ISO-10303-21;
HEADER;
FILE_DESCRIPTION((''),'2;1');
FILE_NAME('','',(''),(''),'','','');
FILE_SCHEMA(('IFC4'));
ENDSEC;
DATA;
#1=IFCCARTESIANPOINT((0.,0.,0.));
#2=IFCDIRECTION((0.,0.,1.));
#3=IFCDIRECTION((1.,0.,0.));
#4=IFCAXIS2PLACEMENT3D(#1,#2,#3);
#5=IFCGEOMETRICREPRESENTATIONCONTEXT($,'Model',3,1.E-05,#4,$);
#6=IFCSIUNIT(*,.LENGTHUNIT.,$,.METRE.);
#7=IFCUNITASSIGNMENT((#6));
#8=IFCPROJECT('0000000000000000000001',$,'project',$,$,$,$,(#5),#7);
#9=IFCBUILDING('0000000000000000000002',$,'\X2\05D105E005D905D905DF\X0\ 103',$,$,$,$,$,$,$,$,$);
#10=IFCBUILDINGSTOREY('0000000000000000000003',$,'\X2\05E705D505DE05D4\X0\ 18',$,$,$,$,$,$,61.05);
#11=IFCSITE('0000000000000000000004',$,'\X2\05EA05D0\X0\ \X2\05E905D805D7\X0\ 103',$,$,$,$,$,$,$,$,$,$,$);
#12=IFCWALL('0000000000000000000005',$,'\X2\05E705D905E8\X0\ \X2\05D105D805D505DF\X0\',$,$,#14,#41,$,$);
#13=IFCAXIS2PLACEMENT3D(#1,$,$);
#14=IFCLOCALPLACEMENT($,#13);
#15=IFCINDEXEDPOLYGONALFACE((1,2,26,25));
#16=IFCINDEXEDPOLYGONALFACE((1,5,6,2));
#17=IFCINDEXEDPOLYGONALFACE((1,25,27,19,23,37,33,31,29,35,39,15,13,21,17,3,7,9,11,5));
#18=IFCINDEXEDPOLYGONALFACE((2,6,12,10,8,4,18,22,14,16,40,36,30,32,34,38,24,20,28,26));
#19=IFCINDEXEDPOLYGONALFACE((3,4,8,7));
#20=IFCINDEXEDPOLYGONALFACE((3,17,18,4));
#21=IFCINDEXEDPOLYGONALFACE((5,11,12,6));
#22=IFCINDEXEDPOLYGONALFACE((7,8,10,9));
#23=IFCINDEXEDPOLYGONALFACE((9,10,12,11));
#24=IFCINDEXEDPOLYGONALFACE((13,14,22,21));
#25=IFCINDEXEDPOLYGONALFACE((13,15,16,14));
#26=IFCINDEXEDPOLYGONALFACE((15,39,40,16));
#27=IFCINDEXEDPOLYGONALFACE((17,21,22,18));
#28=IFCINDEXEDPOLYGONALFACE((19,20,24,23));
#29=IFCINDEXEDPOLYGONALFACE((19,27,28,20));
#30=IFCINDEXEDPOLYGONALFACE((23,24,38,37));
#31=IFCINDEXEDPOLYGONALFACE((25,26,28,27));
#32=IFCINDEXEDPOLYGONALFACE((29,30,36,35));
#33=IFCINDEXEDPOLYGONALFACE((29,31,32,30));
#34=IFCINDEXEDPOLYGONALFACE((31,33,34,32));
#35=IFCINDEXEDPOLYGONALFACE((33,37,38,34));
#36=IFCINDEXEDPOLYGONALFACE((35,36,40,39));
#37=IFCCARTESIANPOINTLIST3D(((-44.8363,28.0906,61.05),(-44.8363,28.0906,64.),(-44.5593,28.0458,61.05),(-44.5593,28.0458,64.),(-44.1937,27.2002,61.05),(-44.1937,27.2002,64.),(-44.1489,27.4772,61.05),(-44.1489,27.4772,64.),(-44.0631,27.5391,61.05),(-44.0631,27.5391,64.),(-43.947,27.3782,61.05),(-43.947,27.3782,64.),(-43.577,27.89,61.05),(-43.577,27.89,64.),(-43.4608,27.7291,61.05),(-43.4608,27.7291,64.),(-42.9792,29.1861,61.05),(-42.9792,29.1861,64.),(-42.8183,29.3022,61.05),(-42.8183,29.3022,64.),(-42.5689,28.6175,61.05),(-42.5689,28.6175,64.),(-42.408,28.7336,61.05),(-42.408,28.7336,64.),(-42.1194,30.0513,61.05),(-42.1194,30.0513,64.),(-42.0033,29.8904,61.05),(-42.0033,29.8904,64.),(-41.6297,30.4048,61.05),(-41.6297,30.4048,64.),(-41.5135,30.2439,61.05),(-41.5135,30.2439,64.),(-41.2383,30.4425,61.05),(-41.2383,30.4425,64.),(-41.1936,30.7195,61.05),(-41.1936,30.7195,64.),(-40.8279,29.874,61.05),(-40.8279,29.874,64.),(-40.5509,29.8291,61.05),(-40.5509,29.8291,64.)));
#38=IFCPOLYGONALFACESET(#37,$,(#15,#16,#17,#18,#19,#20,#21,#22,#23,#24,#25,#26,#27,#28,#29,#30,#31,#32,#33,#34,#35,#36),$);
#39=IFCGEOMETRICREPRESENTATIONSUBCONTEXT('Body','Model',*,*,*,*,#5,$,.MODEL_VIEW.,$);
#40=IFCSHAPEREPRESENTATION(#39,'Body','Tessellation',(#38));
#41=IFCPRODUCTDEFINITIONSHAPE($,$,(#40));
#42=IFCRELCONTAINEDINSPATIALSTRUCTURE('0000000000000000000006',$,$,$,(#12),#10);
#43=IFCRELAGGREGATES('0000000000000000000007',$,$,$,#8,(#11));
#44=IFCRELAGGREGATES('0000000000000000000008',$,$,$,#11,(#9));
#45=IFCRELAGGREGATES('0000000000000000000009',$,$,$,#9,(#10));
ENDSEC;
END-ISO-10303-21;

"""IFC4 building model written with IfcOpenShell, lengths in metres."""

from ifc_helpers import new_model, si_unit, frame, origin_with_axes, context, subcontext, project, spatial, polyline, outline, extrude, element, save


model = new_model("IFC4")

# Units and contexts
model_context = context("Model", 3, precision=1e-05, world=origin_with_axes())
body_context = subcontext(model_context, "Body", "Model", "MODEL_VIEW")
ifc_project = project(units=[si_unit("LENGTHUNIT", "METRE")], contexts=[model_context])

# Site, building, storey
site = spatial("IfcSite", under=ifc_project, Name="תא שטח 103")
building = spatial("IfcBuilding", under=site, Name="בניין 103")
storey = spatial("IfcBuildingStorey", under=building, Name="קומה 18", Elevation=61.05)

# Wall
element("IfcWall", 1, inside=storey, Name="קיר בטון", context=body_context, shape_type="SweptSolid", body=[
    extrude(outline(polyline([(-43.947, 27.3782), (-44.1937, 27.2002), (-44.8363, 28.0906), (-42.1194, 30.0513), (-42.0033, 29.8904), (-42.8183, 29.3022), (-42.408, 28.7336), (-40.8279, 29.874), (-41.2383, 30.4425), (-41.5135, 30.2439), (-41.6297, 30.4048), (-41.1936, 30.7195), (-40.5509, 29.8291), (-43.4608, 27.7291), (-43.577, 27.89), (-42.5689, 28.6175), (-42.9792, 29.1861), (-44.5593, 28.0458), (-44.1489, 27.4772), (-44.0631, 27.5391), (-43.947, 27.3782)])), frame((0.0, 0.0, 61.05)), (0.0, 0.0, 1.0), 2.95),
])

save(model, "model.ifc")
